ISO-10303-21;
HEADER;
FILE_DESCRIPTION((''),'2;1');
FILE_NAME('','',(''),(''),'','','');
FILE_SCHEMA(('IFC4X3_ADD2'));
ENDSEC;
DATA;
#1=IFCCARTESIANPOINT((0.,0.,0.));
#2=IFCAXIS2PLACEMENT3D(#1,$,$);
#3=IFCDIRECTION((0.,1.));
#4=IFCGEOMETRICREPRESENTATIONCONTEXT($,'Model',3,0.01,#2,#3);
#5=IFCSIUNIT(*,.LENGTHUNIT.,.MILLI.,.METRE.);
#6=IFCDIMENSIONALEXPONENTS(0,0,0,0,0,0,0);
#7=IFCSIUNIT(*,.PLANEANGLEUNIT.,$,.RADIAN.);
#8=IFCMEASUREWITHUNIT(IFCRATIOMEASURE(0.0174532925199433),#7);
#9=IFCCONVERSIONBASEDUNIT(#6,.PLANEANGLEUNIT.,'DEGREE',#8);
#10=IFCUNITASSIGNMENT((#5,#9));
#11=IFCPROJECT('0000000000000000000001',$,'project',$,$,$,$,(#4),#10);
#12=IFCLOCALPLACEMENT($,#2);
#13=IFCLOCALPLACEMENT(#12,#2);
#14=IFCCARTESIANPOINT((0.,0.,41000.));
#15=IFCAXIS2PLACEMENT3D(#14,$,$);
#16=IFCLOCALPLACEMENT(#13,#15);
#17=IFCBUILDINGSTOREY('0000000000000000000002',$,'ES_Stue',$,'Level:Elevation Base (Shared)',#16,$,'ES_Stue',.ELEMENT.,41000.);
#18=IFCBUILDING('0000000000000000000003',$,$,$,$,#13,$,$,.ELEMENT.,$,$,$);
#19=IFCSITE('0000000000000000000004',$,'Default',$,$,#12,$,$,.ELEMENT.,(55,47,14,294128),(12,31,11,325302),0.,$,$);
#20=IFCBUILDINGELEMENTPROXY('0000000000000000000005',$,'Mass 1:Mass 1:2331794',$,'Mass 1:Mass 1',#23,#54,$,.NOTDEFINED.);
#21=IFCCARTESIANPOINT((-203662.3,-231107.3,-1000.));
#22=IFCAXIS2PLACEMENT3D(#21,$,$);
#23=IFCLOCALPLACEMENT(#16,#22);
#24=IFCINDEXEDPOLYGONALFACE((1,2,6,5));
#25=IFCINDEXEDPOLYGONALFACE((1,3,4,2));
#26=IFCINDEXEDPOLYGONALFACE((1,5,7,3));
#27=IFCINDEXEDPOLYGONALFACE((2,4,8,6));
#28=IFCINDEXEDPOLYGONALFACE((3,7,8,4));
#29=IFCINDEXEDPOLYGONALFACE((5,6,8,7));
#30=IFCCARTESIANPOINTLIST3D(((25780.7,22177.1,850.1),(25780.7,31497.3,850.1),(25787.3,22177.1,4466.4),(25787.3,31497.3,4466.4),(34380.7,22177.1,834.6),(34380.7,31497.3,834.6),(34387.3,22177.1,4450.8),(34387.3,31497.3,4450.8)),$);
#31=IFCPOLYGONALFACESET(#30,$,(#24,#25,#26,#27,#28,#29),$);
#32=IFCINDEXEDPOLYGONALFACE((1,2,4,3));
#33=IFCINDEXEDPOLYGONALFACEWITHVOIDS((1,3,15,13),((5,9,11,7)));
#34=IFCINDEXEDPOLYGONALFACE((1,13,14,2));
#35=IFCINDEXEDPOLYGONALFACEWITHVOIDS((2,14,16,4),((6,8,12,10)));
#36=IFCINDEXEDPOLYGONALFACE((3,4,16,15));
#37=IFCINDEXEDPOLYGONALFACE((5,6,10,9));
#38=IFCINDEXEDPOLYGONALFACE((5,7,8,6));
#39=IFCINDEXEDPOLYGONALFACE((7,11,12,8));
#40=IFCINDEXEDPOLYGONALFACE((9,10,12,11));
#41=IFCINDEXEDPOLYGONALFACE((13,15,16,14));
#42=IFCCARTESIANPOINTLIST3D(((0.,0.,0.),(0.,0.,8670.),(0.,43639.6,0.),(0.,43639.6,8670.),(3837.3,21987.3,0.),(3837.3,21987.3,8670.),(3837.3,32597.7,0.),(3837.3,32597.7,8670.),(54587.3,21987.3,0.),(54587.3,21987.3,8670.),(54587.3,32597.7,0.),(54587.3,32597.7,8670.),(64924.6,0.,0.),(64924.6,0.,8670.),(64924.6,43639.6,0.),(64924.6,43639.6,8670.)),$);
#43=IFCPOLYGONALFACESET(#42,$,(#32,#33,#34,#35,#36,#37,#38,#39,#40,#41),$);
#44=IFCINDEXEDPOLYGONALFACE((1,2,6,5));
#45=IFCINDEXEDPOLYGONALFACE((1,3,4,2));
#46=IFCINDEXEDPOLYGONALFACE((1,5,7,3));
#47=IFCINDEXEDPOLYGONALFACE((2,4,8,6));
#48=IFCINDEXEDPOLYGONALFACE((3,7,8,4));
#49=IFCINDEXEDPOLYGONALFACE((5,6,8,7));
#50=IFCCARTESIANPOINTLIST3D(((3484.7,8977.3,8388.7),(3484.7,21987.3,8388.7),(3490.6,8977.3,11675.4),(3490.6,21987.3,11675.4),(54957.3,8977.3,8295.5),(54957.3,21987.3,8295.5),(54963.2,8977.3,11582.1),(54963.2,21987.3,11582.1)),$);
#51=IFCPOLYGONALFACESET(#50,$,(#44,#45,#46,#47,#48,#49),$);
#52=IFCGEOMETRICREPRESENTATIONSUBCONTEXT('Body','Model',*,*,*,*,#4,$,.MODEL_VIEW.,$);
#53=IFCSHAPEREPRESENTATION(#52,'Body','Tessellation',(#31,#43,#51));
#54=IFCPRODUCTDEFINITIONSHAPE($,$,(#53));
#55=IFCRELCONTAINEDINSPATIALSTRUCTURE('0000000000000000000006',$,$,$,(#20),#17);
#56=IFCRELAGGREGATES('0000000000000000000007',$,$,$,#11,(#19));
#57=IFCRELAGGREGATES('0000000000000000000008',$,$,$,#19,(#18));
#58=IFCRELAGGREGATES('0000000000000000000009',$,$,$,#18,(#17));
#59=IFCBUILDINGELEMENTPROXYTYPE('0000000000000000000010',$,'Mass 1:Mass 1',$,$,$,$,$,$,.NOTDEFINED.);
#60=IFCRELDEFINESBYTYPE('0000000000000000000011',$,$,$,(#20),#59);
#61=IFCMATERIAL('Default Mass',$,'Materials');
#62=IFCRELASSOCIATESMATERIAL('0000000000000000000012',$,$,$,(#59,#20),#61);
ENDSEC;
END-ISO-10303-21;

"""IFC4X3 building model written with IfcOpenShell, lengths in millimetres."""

from ifc_helpers import new_model, entity, si_unit, converted_unit, direction, frame, frame_2d, origin, place, context, subcontext, project, spatial, rectangle, extrude, source, transform, mapped, material, type_object, type_shapes, element, save


model = new_model("IFC4X3")

# Units and contexts
model_context = context("Model", 3, precision=0.01, world=origin(), true_north=direction((0.0, 1.0)))
body_context = subcontext(model_context, "Body", "Model", "MODEL_VIEW")
ifc_project = project(units=[si_unit("LENGTHUNIT", "METRE", prefix="MILLI"), converted_unit("PLANEANGLEUNIT", "DEGREE", entity("IfcRatioMeasure", 0.0174532925199433), si_unit("PLANEANGLEUNIT", "RADIAN"), dimensions=[0, 0, 0, 0, 0, 0, 0])], contexts=[model_context])

# Site, building, storey
site_placement = place(None, origin())
site = spatial("IfcSite", under=ifc_project, at=site_placement, Name="Default", CompositionType="ELEMENT", RefLatitude=(55, 47, 14, 294128), RefLongitude=(12, 31, 11, 325302), RefElevation=0.0)
building_placement = place(site_placement, origin())
building = spatial("IfcBuilding", under=site, at=building_placement, CompositionType="ELEMENT")
storey_placement = place(building_placement, frame((0.0, 0.0, 41000.0)))
storey = spatial("IfcBuildingStorey", under=building, at=storey_placement, Name="ES_Stue", ObjectType="Level:Elevation Base (Shared)", LongName="ES_Stue", CompositionType="ELEMENT", Elevation=41000.0)

# Building element proxy, opening
ifc_material_1 = material(Name="Default Mass", Category="Materials")
building_element_proxy_type = type_object("IfcBuildingElementProxyType", Name="Mass 1:Mass 1", PredefinedType="NOTDEFINED", material=ifc_material_1)
shared_shape = source(origin(), body_context, "Body", "SweptSolid", [
    extrude(rectangle(XDim=3616.3, YDim=9320.2, at=frame_2d((0.0, 0.0), x_axis=(1.0, 0.0))), frame((25784.0, 26837.2, 2658.3), z_axis=(0.999998, 0.0, -0.001812), x_axis=(0.001812, 0.0, 0.999998)), (0.0, 0.0, 1.0), 8600.0),
    extrude(rectangle(XDim=8670.0, YDim=43639.6, at=frame_2d((0.0, 0.0), x_axis=(1.0, 0.0))), frame((0.0, 21819.8, 4335.0), z_axis=(1.0, 0.0, 0.0), x_axis=(0.0, 0.0, 1.0)), (0.0, 0.0, 1.0), 64924.6),
    extrude(rectangle(XDim=3286.7, YDim=13010.0, at=frame_2d((0.0, 0.0), x_axis=(1.0, 0.0))), frame((3487.7, 15482.3, 10032.1), z_axis=(0.999998, 0.0, -0.001812), x_axis=(0.001812, 0.0, 0.999998)), (0.0, 0.0, 1.0), 51472.7),
])
type_shapes(building_element_proxy_type, [shared_shape])
proxy_placement = place(storey_placement, frame((-203662.3, -231107.3, -1000.0)))
proxy = element("IfcBuildingElementProxy", 1, at=proxy_placement, inside=storey, type_object=building_element_proxy_type, material=ifc_material_1, Name="Mass 1:Mass 1:2331794", ObjectType="Mass 1:Mass 1", PredefinedType="NOTDEFINED", context=body_context, shape_type="MappedRepresentation", body=[
    mapped(shared_shape, transform((0.0, 0.0, 0.0), scale=1.0)),
])
opening_1_placement = place(storey_placement, frame((-203662.3, -231107.3, 40000.0)))
element("IfcOpeningElement", 2, at=opening_1_placement, cuts=proxy, PredefinedType="OPENING", context=body_context, shape_type="SweptSolid", body=[
    extrude(rectangle(XDim=10610.4, YDim=50750.0, at=frame_2d((0.0, 0.0), x_axis=(1.0, 0.0))), frame((29212.3, 27292.5, -41000.0), z_axis=(0.0, 0.0, 1.0), x_axis=(0.0, 1.0, 0.0)), (0.0, 0.0, 1.0), 8670.0),
])

save(model, "model.ifc")
